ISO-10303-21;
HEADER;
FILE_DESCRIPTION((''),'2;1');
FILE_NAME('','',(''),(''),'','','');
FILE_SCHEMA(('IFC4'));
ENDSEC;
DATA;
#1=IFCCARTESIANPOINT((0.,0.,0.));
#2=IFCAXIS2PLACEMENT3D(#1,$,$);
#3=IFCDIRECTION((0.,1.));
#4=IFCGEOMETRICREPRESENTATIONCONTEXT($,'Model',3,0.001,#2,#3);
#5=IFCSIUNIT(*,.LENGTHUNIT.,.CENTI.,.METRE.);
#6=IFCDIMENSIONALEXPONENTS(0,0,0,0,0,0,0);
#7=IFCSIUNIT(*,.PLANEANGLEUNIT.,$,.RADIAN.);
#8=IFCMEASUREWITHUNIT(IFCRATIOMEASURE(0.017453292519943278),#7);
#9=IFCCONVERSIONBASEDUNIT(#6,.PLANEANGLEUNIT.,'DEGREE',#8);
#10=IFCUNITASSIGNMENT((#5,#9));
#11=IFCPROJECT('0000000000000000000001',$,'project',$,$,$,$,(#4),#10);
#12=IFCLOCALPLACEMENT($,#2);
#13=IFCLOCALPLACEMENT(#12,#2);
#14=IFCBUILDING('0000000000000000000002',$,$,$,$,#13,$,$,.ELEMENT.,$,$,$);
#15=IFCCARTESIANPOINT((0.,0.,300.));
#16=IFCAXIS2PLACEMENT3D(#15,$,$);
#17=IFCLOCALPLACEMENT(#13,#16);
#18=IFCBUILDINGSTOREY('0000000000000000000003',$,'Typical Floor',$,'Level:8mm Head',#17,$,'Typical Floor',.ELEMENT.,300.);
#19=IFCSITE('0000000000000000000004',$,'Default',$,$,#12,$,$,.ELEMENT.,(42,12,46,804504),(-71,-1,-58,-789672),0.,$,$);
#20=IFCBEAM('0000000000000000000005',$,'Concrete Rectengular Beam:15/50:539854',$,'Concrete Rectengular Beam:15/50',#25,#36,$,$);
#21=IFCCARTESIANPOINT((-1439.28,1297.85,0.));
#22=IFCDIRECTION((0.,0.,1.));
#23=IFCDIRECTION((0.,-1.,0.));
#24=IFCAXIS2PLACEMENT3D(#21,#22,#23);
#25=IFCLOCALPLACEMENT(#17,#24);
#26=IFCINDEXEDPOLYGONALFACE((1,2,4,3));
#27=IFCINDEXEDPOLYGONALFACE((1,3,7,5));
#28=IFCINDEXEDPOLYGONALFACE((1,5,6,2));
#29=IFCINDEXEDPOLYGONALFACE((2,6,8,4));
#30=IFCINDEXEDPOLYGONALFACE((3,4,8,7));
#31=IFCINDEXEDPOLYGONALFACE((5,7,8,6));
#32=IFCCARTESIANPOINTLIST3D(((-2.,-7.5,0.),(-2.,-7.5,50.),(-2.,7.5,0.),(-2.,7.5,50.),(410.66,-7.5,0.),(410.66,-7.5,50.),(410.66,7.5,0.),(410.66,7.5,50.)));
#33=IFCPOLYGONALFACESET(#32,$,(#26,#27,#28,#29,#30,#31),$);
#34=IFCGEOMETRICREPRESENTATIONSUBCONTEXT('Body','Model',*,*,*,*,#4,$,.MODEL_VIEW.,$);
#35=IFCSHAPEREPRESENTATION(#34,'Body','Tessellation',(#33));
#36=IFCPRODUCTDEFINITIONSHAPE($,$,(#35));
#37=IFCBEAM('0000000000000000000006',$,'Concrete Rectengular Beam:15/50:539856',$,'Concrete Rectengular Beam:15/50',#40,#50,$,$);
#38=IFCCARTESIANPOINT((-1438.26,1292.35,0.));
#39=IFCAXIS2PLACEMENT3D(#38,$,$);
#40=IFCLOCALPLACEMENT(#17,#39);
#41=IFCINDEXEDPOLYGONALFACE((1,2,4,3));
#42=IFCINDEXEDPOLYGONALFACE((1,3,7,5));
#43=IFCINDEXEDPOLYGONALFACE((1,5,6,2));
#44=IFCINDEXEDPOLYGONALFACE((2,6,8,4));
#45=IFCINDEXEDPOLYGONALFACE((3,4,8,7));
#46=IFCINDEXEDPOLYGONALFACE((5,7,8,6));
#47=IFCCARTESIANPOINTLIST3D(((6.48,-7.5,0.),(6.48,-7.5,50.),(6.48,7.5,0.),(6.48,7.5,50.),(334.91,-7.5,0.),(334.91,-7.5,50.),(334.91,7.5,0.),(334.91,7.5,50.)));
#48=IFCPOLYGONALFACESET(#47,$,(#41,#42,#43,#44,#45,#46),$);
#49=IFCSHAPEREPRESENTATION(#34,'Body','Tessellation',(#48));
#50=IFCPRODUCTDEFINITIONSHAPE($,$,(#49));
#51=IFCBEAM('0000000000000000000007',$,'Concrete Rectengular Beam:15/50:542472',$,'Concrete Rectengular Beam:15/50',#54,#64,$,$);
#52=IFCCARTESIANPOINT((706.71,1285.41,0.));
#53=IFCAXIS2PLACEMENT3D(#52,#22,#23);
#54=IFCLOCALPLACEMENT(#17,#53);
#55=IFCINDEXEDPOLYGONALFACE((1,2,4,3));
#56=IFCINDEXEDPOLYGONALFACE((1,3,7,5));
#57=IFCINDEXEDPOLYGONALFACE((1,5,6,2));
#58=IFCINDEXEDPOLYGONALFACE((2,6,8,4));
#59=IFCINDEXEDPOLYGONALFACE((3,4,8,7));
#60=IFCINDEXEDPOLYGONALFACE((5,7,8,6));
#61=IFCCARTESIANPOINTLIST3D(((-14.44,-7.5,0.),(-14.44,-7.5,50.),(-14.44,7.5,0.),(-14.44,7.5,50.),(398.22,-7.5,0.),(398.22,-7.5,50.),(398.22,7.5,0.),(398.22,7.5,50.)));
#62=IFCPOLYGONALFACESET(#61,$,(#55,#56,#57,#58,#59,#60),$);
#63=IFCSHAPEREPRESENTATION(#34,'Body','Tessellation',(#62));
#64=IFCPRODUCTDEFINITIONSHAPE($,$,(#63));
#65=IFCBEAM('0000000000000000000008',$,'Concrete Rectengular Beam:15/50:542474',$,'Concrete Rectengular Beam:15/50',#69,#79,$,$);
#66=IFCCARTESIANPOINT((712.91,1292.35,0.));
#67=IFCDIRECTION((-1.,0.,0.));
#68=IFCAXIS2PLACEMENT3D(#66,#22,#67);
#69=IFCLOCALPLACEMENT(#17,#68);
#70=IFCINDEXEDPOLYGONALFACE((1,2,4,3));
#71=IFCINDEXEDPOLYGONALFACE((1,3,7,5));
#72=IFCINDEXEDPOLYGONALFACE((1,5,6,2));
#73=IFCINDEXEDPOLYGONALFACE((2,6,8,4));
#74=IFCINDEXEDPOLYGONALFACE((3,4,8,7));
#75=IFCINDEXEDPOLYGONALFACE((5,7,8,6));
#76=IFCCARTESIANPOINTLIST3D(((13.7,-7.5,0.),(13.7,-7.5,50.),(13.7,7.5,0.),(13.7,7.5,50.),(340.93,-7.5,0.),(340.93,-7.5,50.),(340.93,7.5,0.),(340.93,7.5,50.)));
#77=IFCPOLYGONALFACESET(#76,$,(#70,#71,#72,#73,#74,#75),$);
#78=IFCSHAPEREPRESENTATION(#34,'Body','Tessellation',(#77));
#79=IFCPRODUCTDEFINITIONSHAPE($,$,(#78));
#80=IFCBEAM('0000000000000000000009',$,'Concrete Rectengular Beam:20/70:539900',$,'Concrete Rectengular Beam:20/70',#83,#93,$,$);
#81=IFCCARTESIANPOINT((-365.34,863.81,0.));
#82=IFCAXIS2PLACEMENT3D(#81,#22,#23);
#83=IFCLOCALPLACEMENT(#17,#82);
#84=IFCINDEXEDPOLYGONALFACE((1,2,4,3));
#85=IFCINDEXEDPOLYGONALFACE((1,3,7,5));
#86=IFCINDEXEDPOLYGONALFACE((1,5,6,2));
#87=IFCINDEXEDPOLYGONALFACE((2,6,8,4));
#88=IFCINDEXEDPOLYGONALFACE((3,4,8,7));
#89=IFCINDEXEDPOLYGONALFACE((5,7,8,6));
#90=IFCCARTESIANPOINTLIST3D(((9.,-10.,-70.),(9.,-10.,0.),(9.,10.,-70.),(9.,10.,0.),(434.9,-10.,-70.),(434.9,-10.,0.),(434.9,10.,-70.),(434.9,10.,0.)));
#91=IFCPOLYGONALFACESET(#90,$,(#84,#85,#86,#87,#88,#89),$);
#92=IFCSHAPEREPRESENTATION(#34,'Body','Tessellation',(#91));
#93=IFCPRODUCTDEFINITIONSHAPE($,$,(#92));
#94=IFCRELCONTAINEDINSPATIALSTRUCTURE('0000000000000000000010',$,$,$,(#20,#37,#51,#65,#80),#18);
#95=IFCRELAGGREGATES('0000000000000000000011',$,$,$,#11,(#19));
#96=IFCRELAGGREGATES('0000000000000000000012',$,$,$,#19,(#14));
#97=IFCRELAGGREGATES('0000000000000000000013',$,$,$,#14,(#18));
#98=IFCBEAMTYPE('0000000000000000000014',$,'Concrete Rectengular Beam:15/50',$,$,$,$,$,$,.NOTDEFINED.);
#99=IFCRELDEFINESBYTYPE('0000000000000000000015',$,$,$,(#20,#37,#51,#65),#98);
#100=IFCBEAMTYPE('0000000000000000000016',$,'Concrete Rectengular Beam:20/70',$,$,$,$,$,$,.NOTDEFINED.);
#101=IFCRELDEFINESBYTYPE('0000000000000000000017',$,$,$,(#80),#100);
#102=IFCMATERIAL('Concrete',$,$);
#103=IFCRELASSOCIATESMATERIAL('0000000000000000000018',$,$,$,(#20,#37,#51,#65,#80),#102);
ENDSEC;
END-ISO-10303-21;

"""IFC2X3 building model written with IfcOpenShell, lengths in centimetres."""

from ifc_helpers import new_model, entity, si_unit, converted_unit, direction, frame, frame_2d, origin, place, context, subcontext, project, spatial, rectangle, extrude, material, type_object, element, save


model = new_model("IFC2X3")

# Units and contexts
model_context = context("Model", 3, precision=0.001, world=origin(), true_north=direction((0.0, 1.0)))
body_context = subcontext(model_context, "Body", "Model", "MODEL_VIEW")
ifc_project = project(units=[si_unit("LENGTHUNIT", "METRE", prefix="CENTI"), converted_unit("PLANEANGLEUNIT", "DEGREE", entity("IfcRatioMeasure", 0.017453292519943278), si_unit("PLANEANGLEUNIT", "RADIAN"), dimensions=[0, 0, 0, 0, 0, 0, 0])], contexts=[model_context])

# Site, building, storey
site_placement = place(None, origin())
site = spatial("IfcSite", under=ifc_project, at=site_placement, Name="Default", CompositionType="ELEMENT", RefLatitude=(42, 12, 46, 804504), RefLongitude=(-71, -1, -58, -789672), RefElevation=0.0)
building_placement = place(site_placement, origin())
building = spatial("IfcBuilding", under=site, at=building_placement, CompositionType="ELEMENT")
storey_placement = place(building_placement, frame((0.0, 0.0, 300.0)))
storey = spatial("IfcBuildingStorey", under=building, at=storey_placement, Name="Typical Floor", ObjectType="Level:8mm Head", LongName="Typical Floor", CompositionType="ELEMENT", Elevation=300.0)

# Beams
ifc_material = material(Name="Concrete")
beam_type_1 = type_object("IfcBeamType", Name="Concrete Rectengular Beam:15/50", PredefinedType="NOTDEFINED")
beam_1_placement = place(storey_placement, frame((-1439.28, 1297.85, 0.0), z_axis=(0.0, 0.0, 1.0), x_axis=(0.0, -1.0, 0.0)))
element("IfcBeam", 1, at=beam_1_placement, inside=storey, type_object=beam_type_1, material=ifc_material, Name="Concrete Rectengular Beam:15/50:539854", ObjectType="Concrete Rectengular Beam:15/50", context=body_context, shape_type="SweptSolid", body=[
    extrude(rectangle(XDim=50.0, YDim=15.0, at=frame_2d((0.0, 0.0), x_axis=(1.0, 0.0))), frame((-2.0, 0.0, 25.0), z_axis=(1.0, 0.0, 0.0), x_axis=(0.0, 0.0, -1.0)), (0.0, 0.0, 1.0), 412.66),
])
beam_2_placement = place(storey_placement, frame((-1438.26, 1292.35, 0.0)))
element("IfcBeam", 2, at=beam_2_placement, inside=storey, type_object=beam_type_1, material=ifc_material, Name="Concrete Rectengular Beam:15/50:539856", ObjectType="Concrete Rectengular Beam:15/50", context=body_context, shape_type="SweptSolid", body=[
    extrude(rectangle(XDim=50.0, YDim=15.0, at=frame_2d((0.0, 0.0), x_axis=(1.0, 0.0))), frame((6.48, 0.0, 25.0), z_axis=(1.0, 0.0, 0.0), x_axis=(0.0, 0.0, -1.0)), (0.0, 0.0, 1.0), 328.43),
])
beam_3_placement = place(storey_placement, frame((706.71, 1285.41, 0.0), z_axis=(0.0, 0.0, 1.0), x_axis=(0.0, -1.0, 0.0)))
element("IfcBeam", 3, at=beam_3_placement, inside=storey, type_object=beam_type_1, material=ifc_material, Name="Concrete Rectengular Beam:15/50:542472", ObjectType="Concrete Rectengular Beam:15/50", context=body_context, shape_type="SweptSolid", body=[
    extrude(rectangle(XDim=50.0, YDim=15.0, at=frame_2d((0.0, 0.0), x_axis=(1.0, 0.0))), frame((-14.44, 0.0, 25.0), z_axis=(1.0, 0.0, 0.0), x_axis=(0.0, 0.0, -1.0)), (0.0, 0.0, 1.0), 412.66),
])
beam_4_placement = place(storey_placement, frame((712.91, 1292.35, 0.0), z_axis=(0.0, 0.0, 1.0), x_axis=(-1.0, 0.0, 0.0)))
element("IfcBeam", 4, at=beam_4_placement, inside=storey, type_object=beam_type_1, material=ifc_material, Name="Concrete Rectengular Beam:15/50:542474", ObjectType="Concrete Rectengular Beam:15/50", context=body_context, shape_type="SweptSolid", body=[
    extrude(rectangle(XDim=50.0, YDim=15.0, at=frame_2d((0.0, 0.0), x_axis=(1.0, 0.0))), frame((13.7, 0.0, 25.0), z_axis=(1.0, 0.0, 0.0), x_axis=(0.0, 0.0, -1.0)), (0.0, 0.0, 1.0), 327.24),
])
beam_type_2 = type_object("IfcBeamType", Name="Concrete Rectengular Beam:20/70", PredefinedType="NOTDEFINED")
beam_5_placement = place(storey_placement, frame((-365.34, 863.81, 0.0), z_axis=(0.0, 0.0, 1.0), x_axis=(0.0, -1.0, 0.0)))
element("IfcBeam", 5, at=beam_5_placement, inside=storey, type_object=beam_type_2, material=ifc_material, Name="Concrete Rectengular Beam:20/70:539900", ObjectType="Concrete Rectengular Beam:20/70", context=body_context, shape_type="SweptSolid", body=[
    extrude(rectangle(XDim=70.0, YDim=20.0, at=frame_2d((0.0, 0.0), x_axis=(1.0, 0.0))), frame((9.0, 0.0, -35.0), z_axis=(1.0, 0.0, 0.0), x_axis=(0.0, 0.0, -1.0)), (0.0, 0.0, 1.0), 425.9),
])

save(model, "model.ifc")
